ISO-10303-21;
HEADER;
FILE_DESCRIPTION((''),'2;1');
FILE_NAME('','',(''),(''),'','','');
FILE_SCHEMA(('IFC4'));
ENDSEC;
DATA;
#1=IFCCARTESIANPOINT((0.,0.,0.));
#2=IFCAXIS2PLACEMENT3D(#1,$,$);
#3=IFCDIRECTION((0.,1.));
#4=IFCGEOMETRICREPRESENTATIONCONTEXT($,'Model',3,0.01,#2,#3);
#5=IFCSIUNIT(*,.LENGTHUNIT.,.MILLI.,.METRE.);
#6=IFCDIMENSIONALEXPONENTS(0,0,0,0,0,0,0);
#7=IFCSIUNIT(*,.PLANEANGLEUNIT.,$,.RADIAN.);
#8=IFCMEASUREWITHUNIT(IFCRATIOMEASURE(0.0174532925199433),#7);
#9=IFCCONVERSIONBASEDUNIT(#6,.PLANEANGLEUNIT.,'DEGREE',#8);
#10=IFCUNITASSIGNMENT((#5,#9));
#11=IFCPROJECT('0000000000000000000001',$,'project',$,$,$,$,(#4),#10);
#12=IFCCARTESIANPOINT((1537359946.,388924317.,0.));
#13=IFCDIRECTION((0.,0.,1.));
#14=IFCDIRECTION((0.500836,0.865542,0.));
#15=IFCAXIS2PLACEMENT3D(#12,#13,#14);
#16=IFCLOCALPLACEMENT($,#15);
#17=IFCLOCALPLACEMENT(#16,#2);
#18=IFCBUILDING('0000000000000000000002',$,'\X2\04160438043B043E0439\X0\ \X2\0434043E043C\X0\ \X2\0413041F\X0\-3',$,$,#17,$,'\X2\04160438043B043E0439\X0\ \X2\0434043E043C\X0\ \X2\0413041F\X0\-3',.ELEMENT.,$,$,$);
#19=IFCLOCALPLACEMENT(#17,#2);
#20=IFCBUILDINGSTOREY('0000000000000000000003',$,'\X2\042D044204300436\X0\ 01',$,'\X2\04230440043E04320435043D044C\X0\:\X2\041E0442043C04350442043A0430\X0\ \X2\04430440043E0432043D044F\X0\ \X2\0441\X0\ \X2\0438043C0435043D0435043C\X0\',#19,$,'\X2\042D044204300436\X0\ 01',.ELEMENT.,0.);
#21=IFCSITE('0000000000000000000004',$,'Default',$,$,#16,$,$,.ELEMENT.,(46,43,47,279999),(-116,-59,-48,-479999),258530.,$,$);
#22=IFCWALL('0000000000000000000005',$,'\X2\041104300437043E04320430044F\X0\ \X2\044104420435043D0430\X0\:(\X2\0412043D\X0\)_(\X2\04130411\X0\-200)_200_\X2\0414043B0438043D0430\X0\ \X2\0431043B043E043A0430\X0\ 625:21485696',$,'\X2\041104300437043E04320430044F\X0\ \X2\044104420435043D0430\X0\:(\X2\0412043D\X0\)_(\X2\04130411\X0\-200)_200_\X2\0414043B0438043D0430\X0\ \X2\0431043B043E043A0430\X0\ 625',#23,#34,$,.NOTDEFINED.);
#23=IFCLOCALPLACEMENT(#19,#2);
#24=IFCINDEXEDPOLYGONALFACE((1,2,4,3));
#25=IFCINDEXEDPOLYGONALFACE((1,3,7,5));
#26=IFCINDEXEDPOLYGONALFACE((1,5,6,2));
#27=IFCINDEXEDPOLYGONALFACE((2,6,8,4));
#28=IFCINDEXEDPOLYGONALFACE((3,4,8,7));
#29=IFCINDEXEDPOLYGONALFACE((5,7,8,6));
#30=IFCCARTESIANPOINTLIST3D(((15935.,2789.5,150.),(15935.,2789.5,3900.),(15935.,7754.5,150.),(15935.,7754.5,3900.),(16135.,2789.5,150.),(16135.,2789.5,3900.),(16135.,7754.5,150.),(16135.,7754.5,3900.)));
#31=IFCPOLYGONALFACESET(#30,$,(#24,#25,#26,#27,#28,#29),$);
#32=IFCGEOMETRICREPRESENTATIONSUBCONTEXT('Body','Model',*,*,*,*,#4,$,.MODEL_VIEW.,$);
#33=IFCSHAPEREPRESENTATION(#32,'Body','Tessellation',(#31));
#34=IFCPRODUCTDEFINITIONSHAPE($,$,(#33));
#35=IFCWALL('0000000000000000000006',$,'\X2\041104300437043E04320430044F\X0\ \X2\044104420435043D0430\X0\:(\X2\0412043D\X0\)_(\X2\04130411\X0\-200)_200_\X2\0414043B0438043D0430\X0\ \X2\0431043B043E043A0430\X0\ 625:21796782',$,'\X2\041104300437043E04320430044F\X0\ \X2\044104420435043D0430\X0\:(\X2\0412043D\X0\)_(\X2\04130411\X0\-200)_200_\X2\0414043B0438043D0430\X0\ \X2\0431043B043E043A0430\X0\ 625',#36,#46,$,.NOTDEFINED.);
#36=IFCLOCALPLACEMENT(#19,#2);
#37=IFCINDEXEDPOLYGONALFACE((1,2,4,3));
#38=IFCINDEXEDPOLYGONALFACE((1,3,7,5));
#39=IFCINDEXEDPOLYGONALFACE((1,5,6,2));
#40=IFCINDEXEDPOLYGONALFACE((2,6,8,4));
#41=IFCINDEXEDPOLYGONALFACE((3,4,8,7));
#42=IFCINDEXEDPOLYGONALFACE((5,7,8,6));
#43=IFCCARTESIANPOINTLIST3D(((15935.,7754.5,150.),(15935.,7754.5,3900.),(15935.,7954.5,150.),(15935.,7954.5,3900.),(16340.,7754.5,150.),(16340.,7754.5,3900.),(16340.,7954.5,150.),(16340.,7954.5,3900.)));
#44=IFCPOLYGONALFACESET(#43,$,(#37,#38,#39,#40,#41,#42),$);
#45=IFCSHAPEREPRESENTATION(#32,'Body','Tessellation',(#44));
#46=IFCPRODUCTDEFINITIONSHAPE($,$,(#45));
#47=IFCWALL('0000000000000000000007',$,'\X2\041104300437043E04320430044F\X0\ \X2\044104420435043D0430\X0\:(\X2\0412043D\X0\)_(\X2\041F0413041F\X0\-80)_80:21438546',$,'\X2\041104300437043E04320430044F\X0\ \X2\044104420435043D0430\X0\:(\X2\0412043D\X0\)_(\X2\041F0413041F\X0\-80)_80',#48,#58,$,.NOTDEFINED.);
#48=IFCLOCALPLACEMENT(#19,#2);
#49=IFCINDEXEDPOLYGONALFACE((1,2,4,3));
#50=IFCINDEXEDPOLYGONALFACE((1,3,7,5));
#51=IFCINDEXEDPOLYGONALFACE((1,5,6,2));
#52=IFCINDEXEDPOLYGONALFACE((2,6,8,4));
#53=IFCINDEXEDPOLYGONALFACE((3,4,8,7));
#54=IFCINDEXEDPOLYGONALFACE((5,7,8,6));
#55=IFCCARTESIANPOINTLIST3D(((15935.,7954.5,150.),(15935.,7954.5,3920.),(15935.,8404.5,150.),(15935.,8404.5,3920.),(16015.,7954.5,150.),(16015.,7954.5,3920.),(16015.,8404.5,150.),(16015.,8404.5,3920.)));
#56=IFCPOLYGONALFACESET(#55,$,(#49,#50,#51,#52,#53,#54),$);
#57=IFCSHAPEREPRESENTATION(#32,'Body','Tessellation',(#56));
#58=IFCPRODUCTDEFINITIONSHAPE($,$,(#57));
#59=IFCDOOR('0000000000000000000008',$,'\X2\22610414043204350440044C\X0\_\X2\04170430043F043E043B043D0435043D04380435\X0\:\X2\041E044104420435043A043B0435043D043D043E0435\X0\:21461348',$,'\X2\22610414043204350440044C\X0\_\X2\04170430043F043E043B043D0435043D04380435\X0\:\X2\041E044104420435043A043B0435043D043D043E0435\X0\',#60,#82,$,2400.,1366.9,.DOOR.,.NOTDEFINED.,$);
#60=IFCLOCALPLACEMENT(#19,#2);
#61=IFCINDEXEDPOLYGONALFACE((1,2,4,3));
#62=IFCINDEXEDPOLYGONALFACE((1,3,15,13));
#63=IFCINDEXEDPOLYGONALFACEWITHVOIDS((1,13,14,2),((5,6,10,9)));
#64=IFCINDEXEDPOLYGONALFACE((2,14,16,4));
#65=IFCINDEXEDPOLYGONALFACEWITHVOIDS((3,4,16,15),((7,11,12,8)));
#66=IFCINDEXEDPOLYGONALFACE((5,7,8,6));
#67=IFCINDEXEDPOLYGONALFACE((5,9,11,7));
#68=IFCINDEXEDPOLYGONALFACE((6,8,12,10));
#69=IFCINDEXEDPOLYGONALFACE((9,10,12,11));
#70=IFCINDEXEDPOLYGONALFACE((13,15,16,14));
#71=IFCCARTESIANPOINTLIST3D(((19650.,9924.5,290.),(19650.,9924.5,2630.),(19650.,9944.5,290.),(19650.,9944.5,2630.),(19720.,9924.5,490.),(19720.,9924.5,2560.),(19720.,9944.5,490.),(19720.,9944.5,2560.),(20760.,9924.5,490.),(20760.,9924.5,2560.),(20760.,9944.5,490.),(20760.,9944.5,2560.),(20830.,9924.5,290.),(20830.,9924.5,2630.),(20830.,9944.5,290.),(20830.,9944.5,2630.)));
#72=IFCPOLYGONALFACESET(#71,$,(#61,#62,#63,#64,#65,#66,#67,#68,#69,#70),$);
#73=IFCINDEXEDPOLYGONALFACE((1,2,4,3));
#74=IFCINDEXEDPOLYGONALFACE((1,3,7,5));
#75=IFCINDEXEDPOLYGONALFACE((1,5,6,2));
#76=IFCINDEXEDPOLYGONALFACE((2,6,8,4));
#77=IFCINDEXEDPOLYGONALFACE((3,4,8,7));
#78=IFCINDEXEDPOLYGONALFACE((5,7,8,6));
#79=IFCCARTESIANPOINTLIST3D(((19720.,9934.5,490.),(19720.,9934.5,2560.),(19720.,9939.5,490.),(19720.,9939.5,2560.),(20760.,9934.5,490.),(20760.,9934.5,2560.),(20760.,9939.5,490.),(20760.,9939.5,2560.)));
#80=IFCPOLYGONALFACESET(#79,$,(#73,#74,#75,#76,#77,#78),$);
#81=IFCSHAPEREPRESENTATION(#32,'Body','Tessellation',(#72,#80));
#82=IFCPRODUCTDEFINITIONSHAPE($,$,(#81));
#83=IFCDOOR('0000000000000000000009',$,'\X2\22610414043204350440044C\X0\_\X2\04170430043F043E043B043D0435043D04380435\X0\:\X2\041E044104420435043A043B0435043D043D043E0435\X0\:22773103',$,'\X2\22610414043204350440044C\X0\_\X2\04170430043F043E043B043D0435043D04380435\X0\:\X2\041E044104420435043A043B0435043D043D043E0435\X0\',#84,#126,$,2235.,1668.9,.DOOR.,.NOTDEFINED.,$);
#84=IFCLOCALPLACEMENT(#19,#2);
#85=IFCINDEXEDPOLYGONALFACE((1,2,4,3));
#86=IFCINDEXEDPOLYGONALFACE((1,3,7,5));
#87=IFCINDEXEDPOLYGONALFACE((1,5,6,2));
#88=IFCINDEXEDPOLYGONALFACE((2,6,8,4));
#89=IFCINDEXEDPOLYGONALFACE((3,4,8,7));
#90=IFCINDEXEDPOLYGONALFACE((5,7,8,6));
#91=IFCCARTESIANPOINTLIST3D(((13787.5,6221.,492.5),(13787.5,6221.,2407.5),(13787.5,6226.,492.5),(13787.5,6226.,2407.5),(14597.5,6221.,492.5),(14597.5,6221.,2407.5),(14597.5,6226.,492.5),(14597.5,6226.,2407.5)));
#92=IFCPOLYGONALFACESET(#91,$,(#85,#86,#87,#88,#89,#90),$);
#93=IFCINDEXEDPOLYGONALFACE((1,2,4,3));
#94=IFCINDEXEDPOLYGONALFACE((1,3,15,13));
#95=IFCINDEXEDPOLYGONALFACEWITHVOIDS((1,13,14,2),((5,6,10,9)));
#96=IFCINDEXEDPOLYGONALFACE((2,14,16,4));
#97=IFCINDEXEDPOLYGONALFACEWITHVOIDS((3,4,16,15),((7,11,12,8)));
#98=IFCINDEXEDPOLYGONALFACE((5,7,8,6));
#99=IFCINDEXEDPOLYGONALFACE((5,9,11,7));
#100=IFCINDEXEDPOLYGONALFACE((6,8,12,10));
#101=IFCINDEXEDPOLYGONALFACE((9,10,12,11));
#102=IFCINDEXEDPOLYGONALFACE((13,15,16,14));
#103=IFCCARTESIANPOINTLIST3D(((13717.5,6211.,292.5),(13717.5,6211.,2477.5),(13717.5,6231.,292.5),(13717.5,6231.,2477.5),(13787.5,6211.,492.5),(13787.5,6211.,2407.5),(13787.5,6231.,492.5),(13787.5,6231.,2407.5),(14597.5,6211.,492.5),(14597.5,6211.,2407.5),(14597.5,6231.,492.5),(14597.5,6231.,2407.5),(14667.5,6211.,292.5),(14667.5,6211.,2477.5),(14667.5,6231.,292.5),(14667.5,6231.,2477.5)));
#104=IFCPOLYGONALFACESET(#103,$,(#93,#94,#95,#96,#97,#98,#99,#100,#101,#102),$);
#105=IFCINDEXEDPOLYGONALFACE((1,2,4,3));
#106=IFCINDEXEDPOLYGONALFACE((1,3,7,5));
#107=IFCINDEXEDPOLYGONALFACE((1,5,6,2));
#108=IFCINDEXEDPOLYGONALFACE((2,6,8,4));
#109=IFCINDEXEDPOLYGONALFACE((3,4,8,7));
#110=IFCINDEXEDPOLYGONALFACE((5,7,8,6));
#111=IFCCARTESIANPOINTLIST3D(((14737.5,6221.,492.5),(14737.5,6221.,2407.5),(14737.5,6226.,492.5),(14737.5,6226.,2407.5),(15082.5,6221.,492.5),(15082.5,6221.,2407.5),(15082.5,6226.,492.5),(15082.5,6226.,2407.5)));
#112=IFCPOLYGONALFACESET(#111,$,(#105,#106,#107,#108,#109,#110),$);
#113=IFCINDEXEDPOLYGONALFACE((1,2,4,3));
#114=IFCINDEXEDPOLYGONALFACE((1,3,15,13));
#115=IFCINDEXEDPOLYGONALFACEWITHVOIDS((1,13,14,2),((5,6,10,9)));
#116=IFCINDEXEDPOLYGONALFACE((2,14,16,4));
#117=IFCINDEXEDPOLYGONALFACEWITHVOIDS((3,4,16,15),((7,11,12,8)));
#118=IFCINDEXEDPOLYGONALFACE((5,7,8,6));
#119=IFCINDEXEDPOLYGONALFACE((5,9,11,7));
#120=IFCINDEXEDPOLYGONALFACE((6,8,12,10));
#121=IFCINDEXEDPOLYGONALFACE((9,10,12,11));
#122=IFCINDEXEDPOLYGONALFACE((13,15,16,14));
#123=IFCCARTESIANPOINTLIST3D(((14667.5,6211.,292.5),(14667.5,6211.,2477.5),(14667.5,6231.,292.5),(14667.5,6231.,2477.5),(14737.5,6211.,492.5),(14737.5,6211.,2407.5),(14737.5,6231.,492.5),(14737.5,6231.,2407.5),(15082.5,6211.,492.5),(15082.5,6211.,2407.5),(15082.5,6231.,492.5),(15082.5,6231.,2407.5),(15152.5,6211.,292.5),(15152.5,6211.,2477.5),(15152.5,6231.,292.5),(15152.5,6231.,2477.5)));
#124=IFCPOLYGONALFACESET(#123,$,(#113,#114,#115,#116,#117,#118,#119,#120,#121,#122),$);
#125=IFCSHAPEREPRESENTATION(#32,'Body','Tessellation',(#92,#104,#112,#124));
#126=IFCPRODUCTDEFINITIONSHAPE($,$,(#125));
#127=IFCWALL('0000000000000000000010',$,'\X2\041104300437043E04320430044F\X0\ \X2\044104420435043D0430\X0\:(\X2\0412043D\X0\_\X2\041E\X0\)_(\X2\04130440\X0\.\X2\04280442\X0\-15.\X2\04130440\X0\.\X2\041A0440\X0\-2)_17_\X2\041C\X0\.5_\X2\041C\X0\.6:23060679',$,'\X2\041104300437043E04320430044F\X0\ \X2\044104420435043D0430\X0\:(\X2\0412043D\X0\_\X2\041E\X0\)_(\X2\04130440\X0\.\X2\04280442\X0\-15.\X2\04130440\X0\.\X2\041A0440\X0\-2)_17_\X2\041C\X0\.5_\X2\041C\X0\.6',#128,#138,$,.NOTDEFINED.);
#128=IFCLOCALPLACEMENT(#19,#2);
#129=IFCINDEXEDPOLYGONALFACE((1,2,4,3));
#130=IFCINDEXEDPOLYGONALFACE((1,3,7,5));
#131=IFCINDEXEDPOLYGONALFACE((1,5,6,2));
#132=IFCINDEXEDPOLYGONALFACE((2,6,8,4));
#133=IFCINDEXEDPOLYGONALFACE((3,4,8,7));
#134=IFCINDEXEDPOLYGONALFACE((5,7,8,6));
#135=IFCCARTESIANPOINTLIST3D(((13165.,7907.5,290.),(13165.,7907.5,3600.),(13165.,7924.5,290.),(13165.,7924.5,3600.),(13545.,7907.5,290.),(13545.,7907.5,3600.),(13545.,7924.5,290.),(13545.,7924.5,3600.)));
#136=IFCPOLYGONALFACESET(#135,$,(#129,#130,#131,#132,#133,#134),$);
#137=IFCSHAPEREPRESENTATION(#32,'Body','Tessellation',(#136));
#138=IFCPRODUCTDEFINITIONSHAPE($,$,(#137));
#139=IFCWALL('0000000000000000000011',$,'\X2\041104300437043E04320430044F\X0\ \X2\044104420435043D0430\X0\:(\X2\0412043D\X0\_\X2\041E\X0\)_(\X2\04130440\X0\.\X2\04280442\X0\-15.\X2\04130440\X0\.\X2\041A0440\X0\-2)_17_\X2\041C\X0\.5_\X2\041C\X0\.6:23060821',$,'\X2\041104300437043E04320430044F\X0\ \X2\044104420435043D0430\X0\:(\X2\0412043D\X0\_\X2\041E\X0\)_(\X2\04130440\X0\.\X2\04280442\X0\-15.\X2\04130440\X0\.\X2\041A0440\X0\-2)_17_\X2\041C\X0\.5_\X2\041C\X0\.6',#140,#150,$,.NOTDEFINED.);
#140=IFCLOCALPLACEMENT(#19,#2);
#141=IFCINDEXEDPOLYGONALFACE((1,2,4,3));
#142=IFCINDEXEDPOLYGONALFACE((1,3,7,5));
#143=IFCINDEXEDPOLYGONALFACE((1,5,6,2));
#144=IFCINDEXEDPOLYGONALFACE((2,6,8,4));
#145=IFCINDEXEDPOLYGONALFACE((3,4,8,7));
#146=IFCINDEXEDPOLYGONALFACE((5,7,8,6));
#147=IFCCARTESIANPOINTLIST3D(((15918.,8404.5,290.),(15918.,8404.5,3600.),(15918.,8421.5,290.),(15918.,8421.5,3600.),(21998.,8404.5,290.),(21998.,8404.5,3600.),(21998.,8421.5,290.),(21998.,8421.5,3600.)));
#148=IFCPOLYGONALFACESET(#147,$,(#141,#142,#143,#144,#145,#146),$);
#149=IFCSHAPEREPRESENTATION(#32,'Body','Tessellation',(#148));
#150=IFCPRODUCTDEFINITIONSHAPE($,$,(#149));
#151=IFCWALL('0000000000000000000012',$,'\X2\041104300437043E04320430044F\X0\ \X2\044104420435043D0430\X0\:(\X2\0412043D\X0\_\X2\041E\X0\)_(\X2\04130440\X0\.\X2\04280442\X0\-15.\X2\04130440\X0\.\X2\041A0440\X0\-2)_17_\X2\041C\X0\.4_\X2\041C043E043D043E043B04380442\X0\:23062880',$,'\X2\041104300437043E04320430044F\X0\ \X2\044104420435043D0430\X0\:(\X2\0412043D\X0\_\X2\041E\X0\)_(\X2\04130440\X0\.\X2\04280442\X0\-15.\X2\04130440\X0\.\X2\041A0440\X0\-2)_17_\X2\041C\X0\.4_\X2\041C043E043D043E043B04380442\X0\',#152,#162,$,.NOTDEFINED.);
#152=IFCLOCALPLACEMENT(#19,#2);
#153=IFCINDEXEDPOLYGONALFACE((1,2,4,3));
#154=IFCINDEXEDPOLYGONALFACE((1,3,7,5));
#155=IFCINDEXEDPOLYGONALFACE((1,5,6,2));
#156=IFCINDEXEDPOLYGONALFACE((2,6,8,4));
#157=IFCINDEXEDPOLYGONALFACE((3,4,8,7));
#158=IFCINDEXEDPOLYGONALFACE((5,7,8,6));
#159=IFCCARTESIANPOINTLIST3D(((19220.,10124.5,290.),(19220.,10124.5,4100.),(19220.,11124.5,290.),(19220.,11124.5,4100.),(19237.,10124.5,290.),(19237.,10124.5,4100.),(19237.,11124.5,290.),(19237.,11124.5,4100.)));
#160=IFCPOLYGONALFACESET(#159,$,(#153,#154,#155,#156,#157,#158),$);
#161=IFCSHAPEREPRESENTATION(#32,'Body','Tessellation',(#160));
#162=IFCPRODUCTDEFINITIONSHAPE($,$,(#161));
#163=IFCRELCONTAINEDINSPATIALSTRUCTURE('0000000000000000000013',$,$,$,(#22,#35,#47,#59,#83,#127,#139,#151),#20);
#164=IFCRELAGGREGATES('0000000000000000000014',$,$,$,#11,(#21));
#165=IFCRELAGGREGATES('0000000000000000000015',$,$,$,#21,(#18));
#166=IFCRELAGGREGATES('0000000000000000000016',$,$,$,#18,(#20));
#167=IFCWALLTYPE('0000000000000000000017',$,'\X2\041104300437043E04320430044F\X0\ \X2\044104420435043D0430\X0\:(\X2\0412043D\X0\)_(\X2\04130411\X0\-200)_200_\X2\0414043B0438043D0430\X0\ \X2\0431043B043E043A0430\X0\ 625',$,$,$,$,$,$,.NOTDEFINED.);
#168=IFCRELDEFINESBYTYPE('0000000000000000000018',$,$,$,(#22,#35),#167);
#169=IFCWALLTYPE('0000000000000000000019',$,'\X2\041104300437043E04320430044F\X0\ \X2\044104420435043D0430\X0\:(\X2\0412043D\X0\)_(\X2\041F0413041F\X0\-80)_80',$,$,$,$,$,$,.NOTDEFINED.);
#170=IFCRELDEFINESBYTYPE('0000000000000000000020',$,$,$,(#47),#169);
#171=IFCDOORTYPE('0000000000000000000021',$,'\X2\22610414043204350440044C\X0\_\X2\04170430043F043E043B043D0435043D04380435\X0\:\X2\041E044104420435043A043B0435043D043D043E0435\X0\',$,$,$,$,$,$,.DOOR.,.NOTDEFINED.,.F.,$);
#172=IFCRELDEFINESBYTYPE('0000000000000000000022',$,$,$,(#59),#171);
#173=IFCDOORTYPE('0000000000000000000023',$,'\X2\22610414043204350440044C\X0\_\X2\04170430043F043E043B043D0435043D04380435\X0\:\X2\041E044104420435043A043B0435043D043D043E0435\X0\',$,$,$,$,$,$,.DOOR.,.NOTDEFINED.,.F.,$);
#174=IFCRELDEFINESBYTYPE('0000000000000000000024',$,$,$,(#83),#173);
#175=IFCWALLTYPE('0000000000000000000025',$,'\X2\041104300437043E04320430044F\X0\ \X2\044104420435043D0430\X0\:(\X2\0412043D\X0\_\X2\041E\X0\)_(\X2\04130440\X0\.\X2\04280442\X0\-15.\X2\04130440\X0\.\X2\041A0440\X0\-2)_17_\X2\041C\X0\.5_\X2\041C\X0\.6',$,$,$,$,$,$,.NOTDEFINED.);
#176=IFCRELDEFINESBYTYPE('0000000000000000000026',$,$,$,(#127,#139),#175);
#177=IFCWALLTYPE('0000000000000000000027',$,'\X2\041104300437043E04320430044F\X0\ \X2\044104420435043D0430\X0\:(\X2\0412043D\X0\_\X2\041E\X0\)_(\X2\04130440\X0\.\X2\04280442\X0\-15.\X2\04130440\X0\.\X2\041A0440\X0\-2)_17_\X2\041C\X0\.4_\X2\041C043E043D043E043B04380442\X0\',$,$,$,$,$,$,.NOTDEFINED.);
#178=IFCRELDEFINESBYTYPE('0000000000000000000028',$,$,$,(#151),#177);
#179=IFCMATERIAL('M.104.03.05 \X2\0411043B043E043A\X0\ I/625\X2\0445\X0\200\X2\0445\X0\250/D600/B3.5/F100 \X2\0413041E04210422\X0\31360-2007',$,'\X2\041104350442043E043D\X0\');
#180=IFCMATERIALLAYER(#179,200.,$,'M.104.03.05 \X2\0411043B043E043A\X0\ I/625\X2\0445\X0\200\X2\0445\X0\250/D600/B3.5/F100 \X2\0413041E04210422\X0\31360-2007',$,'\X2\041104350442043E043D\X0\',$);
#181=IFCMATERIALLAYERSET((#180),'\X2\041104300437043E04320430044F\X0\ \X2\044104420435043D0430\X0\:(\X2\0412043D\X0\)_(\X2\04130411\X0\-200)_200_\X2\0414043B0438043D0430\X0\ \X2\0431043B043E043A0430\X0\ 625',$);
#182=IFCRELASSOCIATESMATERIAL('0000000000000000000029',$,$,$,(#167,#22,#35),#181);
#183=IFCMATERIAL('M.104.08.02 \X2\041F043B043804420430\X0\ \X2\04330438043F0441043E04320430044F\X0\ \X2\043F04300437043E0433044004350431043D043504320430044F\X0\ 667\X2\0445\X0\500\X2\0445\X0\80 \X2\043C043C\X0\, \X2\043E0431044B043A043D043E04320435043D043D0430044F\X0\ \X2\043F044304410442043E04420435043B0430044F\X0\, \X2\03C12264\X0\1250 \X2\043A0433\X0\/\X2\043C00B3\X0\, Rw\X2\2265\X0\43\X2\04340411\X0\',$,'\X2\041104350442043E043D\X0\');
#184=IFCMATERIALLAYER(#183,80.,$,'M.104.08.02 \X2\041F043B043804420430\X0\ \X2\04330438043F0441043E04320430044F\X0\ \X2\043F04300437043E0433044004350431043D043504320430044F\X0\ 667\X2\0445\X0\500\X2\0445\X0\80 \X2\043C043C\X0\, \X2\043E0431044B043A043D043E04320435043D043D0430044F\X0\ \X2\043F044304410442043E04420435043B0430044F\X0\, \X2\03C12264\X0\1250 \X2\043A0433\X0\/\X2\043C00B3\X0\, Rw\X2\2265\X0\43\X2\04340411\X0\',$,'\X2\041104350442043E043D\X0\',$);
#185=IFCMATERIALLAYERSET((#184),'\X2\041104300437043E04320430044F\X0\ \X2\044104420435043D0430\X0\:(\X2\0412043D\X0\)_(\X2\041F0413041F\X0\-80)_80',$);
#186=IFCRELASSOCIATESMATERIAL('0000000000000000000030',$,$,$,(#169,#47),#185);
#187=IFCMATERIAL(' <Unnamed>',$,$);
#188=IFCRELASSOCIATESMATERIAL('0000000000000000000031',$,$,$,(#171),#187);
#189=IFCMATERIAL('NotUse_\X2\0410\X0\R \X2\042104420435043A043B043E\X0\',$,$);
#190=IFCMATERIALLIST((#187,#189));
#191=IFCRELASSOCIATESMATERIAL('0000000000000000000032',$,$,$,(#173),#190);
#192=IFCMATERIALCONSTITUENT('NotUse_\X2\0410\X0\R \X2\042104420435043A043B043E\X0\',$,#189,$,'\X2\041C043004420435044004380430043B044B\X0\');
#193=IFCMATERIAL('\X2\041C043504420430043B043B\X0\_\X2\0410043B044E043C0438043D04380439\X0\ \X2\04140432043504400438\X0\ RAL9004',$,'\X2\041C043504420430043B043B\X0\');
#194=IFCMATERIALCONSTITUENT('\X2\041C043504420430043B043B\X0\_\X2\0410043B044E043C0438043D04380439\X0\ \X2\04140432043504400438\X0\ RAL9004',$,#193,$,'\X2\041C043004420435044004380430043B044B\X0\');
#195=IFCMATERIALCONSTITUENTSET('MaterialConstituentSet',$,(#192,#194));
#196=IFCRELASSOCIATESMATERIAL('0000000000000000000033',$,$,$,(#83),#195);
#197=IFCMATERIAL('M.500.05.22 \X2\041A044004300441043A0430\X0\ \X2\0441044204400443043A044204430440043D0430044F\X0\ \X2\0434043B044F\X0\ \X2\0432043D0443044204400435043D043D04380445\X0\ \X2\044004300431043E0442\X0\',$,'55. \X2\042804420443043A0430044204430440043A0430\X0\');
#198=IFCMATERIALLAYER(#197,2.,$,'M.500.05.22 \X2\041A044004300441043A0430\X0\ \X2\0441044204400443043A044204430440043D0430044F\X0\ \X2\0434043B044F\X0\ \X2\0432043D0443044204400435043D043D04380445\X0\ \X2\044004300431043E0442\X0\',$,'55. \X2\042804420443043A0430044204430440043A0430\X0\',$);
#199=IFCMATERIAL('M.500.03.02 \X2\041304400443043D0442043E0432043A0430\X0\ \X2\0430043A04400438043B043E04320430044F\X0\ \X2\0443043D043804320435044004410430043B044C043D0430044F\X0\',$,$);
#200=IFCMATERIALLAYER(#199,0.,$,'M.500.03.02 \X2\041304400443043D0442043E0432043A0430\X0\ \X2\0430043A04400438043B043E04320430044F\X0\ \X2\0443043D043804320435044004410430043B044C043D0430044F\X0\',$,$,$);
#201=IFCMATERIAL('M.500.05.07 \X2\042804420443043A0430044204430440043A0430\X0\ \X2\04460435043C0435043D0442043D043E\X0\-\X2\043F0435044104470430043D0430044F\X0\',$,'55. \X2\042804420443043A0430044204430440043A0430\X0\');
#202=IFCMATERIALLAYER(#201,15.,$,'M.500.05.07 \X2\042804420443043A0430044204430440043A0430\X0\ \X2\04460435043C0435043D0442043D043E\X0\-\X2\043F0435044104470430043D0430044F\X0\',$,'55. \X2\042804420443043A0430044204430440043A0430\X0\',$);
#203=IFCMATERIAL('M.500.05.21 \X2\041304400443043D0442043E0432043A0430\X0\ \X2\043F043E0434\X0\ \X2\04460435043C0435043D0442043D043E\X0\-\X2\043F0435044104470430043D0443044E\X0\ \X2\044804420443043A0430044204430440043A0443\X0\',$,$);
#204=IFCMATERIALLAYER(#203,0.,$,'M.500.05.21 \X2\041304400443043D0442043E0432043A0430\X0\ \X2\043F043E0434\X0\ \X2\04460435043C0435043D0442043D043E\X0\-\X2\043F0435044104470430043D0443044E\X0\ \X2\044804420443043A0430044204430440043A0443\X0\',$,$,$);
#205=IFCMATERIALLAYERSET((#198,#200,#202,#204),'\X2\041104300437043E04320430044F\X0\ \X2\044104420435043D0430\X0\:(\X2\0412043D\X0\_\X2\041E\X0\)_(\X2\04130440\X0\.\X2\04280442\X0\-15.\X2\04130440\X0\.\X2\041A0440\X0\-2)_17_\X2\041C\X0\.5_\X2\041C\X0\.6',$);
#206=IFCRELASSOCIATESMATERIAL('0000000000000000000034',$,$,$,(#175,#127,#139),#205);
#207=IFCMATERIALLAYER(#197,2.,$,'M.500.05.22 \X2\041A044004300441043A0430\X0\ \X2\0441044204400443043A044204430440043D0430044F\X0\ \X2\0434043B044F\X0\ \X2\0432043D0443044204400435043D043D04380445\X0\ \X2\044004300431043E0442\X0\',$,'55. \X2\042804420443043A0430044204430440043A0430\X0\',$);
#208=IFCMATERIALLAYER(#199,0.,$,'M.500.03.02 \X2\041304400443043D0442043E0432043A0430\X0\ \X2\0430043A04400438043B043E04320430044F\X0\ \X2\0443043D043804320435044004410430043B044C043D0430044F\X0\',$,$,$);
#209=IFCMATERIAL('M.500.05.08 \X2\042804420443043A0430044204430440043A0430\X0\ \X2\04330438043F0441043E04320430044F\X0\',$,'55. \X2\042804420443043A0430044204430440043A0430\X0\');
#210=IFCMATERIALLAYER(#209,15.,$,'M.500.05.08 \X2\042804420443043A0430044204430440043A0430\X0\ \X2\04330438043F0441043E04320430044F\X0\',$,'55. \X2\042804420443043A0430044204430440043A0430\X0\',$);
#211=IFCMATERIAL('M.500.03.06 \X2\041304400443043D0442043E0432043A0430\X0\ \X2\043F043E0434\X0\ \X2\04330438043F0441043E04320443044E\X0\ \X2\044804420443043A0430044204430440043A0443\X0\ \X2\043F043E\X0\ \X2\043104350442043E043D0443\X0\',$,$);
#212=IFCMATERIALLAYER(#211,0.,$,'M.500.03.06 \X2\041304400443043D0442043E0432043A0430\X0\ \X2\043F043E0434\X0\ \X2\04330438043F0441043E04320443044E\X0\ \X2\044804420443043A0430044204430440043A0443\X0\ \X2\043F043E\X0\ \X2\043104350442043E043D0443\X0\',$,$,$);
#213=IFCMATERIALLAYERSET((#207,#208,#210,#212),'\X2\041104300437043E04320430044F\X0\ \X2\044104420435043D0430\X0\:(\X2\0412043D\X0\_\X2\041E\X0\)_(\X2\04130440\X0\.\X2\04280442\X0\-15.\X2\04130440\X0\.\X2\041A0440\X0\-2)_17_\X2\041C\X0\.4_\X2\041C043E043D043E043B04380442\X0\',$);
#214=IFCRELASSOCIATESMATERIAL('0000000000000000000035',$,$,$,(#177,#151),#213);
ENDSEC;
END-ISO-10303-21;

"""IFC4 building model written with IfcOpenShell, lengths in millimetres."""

from ifc_helpers import new_model, entity, si_unit, converted_unit, direction, frame, frame_2d, origin, place, context, subcontext, project, spatial, polyline, rectangle, outline, extrude, source, transform, mapped, material, material_list, layer, layer_set, layer_usage, constituent, constituent_set, type_object, type_shapes, element, save


model = new_model("IFC4")

# Units and contexts
model_context = context("Model", 3, precision=0.01, world=origin(), true_north=direction((0.0, 1.0)))
body_context = subcontext(model_context, "Body", "Model", "MODEL_VIEW")
ifc_project = project(units=[si_unit("LENGTHUNIT", "METRE", prefix="MILLI"), converted_unit("PLANEANGLEUNIT", "DEGREE", entity("IfcRatioMeasure", 0.0174532925199433), si_unit("PLANEANGLEUNIT", "RADIAN"), dimensions=[0, 0, 0, 0, 0, 0, 0])], contexts=[model_context])

# Site, building, storey
site_placement = place(None, frame((1537359946.0, 388924317.0, 0.0), z_axis=(0.0, 0.0, 1.0), x_axis=(0.500836, 0.865542, 0.0)))
site = spatial("IfcSite", under=ifc_project, at=site_placement, Name="Default", CompositionType="ELEMENT", RefLatitude=(46, 43, 47, 279999), RefLongitude=(-116, -59, -48, -479999), RefElevation=258530.0)
building_placement = place(site_placement, origin())
building = spatial("IfcBuilding", under=site, at=building_placement, Name="Жилой дом ГП-3", LongName="Жилой дом ГП-3", CompositionType="ELEMENT")
storey_placement = place(building_placement, origin())
storey = spatial("IfcBuildingStorey", under=building, at=storey_placement, Name="Этаж 01", ObjectType="Уровень:Отметка уровня с именем", LongName="Этаж 01", CompositionType="ELEMENT", Elevation=0.0)

# Walls
ifc_material_1 = material(Name="M.104.03.05 Блок I/625х200х250/D600/B3.5/F100 ГОСТ31360-2007", Category="Бетон")
ifc_layer_1 = layer(ifc_material_1, 200.0, Name="M.104.03.05 Блок I/625х200х250/D600/B3.5/F100 ГОСТ31360-2007", Category="Бетон")
ifc_layer_set_1 = layer_set([ifc_layer_1], Name="Базовая стена:(Вн)_(ГБ-200)_200_Длина блока 625")
ifc_layer_usage_1 = layer_usage(ifc_layer_set_1, "AXIS2", "NEGATIVE", 100.0)
wall_type_1 = type_object("IfcWallType", Name="Базовая стена:(Вн)_(ГБ-200)_200_Длина блока 625", PredefinedType="NOTDEFINED", material=ifc_layer_set_1)
wall_1_placement = place(storey_placement, frame((16035.0, 7754.5, 150.0), z_axis=(0.0, 0.0, 1.0), x_axis=(0.0, -1.0, 0.0)))
element("IfcWall", 1, at=wall_1_placement, inside=storey, type_object=wall_type_1, material=ifc_layer_usage_1, Name="Базовая стена:(Вн)_(ГБ-200)_200_Длина блока 625:21485696", ObjectType="Базовая стена:(Вн)_(ГБ-200)_200_Длина блока 625", PredefinedType="NOTDEFINED", context=body_context, shape_type="SweptSolid", body=[
    extrude(rectangle(XDim=4965.0, YDim=200.0, at=frame_2d((2482.5, 0.0), x_axis=(-1.0, 0.0))), origin(), (0.0, 0.0, 1.0), 3750.0),
])
ifc_layer_usage_2 = layer_usage(ifc_layer_set_1, "AXIS2", "NEGATIVE", 100.0)
wall_2_placement = place(storey_placement, frame((16340.0, 7854.5, 150.0), z_axis=(0.0, 0.0, 1.0), x_axis=(-1.0, 0.0, 0.0)))
element("IfcWall", 2, at=wall_2_placement, inside=storey, type_object=wall_type_1, material=ifc_layer_usage_2, Name="Базовая стена:(Вн)_(ГБ-200)_200_Длина блока 625:21796782", ObjectType="Базовая стена:(Вн)_(ГБ-200)_200_Длина блока 625", PredefinedType="NOTDEFINED", context=body_context, shape_type="SweptSolid", body=[
    extrude(rectangle(XDim=405.0, YDim=200.0, at=frame_2d((202.5, 0.0), x_axis=(-1.0, 0.0))), origin(), (0.0, 0.0, 1.0), 3750.0),
])
ifc_material_2 = material(Name="M.104.08.02 Плита гипсовая пазогребневая 667х500х80 мм, обыкновенная пустотелая, ρ≤1250 кг/м³, Rw≥43дБ", Category="Бетон")
ifc_layer_2 = layer(ifc_material_2, 80.0, Name="M.104.08.02 Плита гипсовая пазогребневая 667х500х80 мм, обыкновенная пустотелая, ρ≤1250 кг/м³, Rw≥43дБ", Category="Бетон")
ifc_layer_set_2 = layer_set([ifc_layer_2], Name="Базовая стена:(Вн)_(ПГП-80)_80")
ifc_layer_usage_3 = layer_usage(ifc_layer_set_2, "AXIS2", "NEGATIVE", 40.0)
wall_type_2 = type_object("IfcWallType", Name="Базовая стена:(Вн)_(ПГП-80)_80", PredefinedType="NOTDEFINED", material=ifc_layer_set_2)
wall_3_placement = place(storey_placement, frame((15975.0, 7954.5, 150.0), z_axis=(0.0, 0.0, 1.0), x_axis=(0.0, 1.0, 0.0)))
element("IfcWall", 3, at=wall_3_placement, inside=storey, type_object=wall_type_2, material=ifc_layer_usage_3, Name="Базовая стена:(Вн)_(ПГП-80)_80:21438546", ObjectType="Базовая стена:(Вн)_(ПГП-80)_80", PredefinedType="NOTDEFINED", context=body_context, shape_type="SweptSolid", body=[
    extrude(rectangle(XDim=450.0, YDim=80.0, at=frame_2d((225.0, 0.0), x_axis=(-1.0, 0.0))), origin(), (0.0, 0.0, 1.0), 3770.0),
])

# Doors
ifc_material_3 = material(Name=" <Unnamed>")
door_type_1 = type_object("IfcDoorType", Name="≡Дверь_Заполнение:Остекленное", OperationType="NOTDEFINED", ParameterTakesPrecedence=False, PredefinedType="DOOR", material=ifc_material_3)
shared_shape_1 = source(origin(), body_context, "Body", "SweptSolid", [
    extrude(outline(polyline([(-1170.0, -590.0), (1170.0, -590.0), (1170.0, 590.0), (-1170.0, 590.0), (-1170.0, -590.0)]), holes=[polyline([(-1100.0, -520.0), (-1100.0, 520.0), (970.0, 520.0), (970.0, -520.0), (-1100.0, -520.0)])]), frame((0.0, -20.0, 1170.0), z_axis=(0.0, 1.0, 0.0), x_axis=(0.0, 0.0, -1.0)), (0.0, 0.0, 1.0), 20.0),
    extrude(rectangle(XDim=5.0, YDim=1040.0, at=frame_2d((0.0, 0.0), x_axis=(1.0, 0.0))), frame((0.0, -12.5, 200.0), z_axis=(0.0, 0.0, 1.0), x_axis=(0.0, 1.0, 0.0)), (0.0, 0.0, 1.0), 2070.0),
])
type_shapes(door_type_1, [shared_shape_1])
door_1_placement = place(storey_placement, frame((20240.0, 9924.5, 290.0), z_axis=(0.0, 0.0, 1.0), x_axis=(-1.0, 0.0, 0.0)))
element("IfcDoor", 4, at=door_1_placement, inside=storey, type_object=door_type_1, Name="≡Дверь_Заполнение:Остекленное:21461348", ObjectType="≡Дверь_Заполнение:Остекленное", OperationType="NOTDEFINED", OverallHeight=2400.0, OverallWidth=1366.9, PredefinedType="DOOR", context=body_context, shape_type="MappedRepresentation", body=[
    mapped(shared_shape_1, transform((0.0, 0.0, 0.0), scale=1.0)),
])
ifc_material_4 = material(Name="NotUse_АR Стекло")
ifc_constituent_1 = constituent(ifc_material_4, Name="NotUse_АR Стекло", Category="Материалы")
ifc_material_5 = material(Name="Металл_Алюминий Двери RAL9004", Category="Металл")
ifc_constituent_2 = constituent(ifc_material_5, Name="Металл_Алюминий Двери RAL9004", Category="Материалы")
ifc_constituent_set = constituent_set(constituents=[ifc_constituent_1, ifc_constituent_2], Name="MaterialConstituentSet")
ifc_material_list = material_list([ifc_material_3, ifc_material_4])
door_type_2 = type_object("IfcDoorType", Name="≡Дверь_Заполнение:Остекленное", OperationType="NOTDEFINED", ParameterTakesPrecedence=False, PredefinedType="DOOR", material=ifc_material_list)
shared_shape_2 = source(origin(), body_context, "Body", "SweptSolid", [
    extrude(rectangle(XDim=810.0, YDim=5.0, at=frame_2d((0.0, 0.0), x_axis=(1.0, 0.0))), frame((-242.5, 12.5, 200.0), z_axis=(0.0, 0.0, 1.0), x_axis=(-1.0, 0.0, 0.0)), (0.0, 0.0, 1.0), 1915.0),
    extrude(outline(polyline([(-1092.5, -475.0), (1092.5, -475.0), (1092.5, 475.0), (-1092.5, 475.0), (-1092.5, -475.0)]), holes=[polyline([(-1022.5, -405.0), (-1022.5, 405.0), (892.5, 405.0), (892.5, -405.0), (-1022.5, -405.0)])]), frame((-242.5, 0.0, 1092.5), z_axis=(0.0, 1.0, 0.0), x_axis=(0.0, 0.0, -1.0)), (0.0, 0.0, 1.0), 20.0),
    extrude(rectangle(XDim=345.0, YDim=5.0, at=frame_2d((0.0, 0.0), x_axis=(1.0, 0.0))), frame((475.0, 12.5, 200.0), z_axis=(0.0, 0.0, 1.0), x_axis=(-1.0, 0.0, 0.0)), (0.0, 0.0, 1.0), 1915.0),
    extrude(outline(polyline([(-1092.5, -242.5), (1092.5, -242.5), (1092.5, 242.5), (-1092.5, 242.5), (-1092.5, -242.5)]), holes=[polyline([(-1022.5, -172.5), (-1022.5, 172.5), (892.5, 172.5), (892.5, -172.5), (-1022.5, -172.5)])]), frame((475.0, 0.0, 1092.5), z_axis=(0.0, 1.0, 0.0), x_axis=(0.0, 0.0, -1.0)), (0.0, 0.0, 1.0), 20.0),
])
type_shapes(door_type_2, [shared_shape_2])
door_2_placement = place(storey_placement, frame((14435.0, 6211.0, 292.5)))
element("IfcDoor", 5, at=door_2_placement, inside=storey, type_object=door_type_2, material=ifc_constituent_set, Name="≡Дверь_Заполнение:Остекленное:22773103", ObjectType="≡Дверь_Заполнение:Остекленное", OperationType="NOTDEFINED", OverallHeight=2235.0, OverallWidth=1668.9, PredefinedType="DOOR", context=body_context, shape_type="MappedRepresentation", body=[
    mapped(shared_shape_2, transform((0.0, 0.0, 0.0), scale=1.0)),
])

# Walls
ifc_material_6 = material(Name="M.500.05.22 Краска структурная для внутренних работ", Category="55. Штукатурка")
ifc_layer_3 = layer(ifc_material_6, 2.0, Name="M.500.05.22 Краска структурная для внутренних работ", Category="55. Штукатурка")
ifc_material_7 = material(Name="M.500.03.02 Грунтовка акриловая универсальная")
ifc_layer_4 = layer(ifc_material_7, 0.0, Name="M.500.03.02 Грунтовка акриловая универсальная")
ifc_material_8 = material(Name="M.500.05.07 Штукатурка цементно-песчаная", Category="55. Штукатурка")
ifc_layer_5 = layer(ifc_material_8, 15.0, Name="M.500.05.07 Штукатурка цементно-песчаная", Category="55. Штукатурка")
ifc_material_9 = material(Name="M.500.05.21 Грунтовка под цементно-песчаную штукатурку")
ifc_layer_6 = layer(ifc_material_9, 0.0, Name="M.500.05.21 Грунтовка под цементно-песчаную штукатурку")
ifc_layer_set_3 = layer_set([ifc_layer_3, ifc_layer_4, ifc_layer_5, ifc_layer_6], Name="Базовая стена:(Вн_О)_(Гр.Шт-15.Гр.Кр-2)_17_М.5_М.6")
ifc_layer_usage_4 = layer_usage(ifc_layer_set_3, "AXIS2", "NEGATIVE", 8.5)
wall_type_3 = type_object("IfcWallType", Name="Базовая стена:(Вн_О)_(Гр.Шт-15.Гр.Кр-2)_17_М.5_М.6", PredefinedType="NOTDEFINED", material=ifc_layer_set_3)
wall_4_placement = place(storey_placement, frame((13545.0, 7916.0, 290.0), z_axis=(0.0, 0.0, 1.0), x_axis=(-1.0, 0.0, 0.0)))
element("IfcWall", 6, at=wall_4_placement, inside=storey, type_object=wall_type_3, material=ifc_layer_usage_4, Name="Базовая стена:(Вн_О)_(Гр.Шт-15.Гр.Кр-2)_17_М.5_М.6:23060679", ObjectType="Базовая стена:(Вн_О)_(Гр.Шт-15.Гр.Кр-2)_17_М.5_М.6", PredefinedType="NOTDEFINED", context=body_context, shape_type="SweptSolid", body=[
    extrude(rectangle(XDim=380.0, YDim=17.0, at=frame_2d((190.0, 0.0), x_axis=(-1.0, 0.0))), origin(), (0.0, 0.0, 1.0), 3310.0),
])
ifc_layer_usage_5 = layer_usage(ifc_layer_set_3, "AXIS2", "NEGATIVE", 8.5)
wall_5_placement = place(storey_placement, frame((15918.0, 8413.0, 290.0)))
element("IfcWall", 7, at=wall_5_placement, inside=storey, type_object=wall_type_3, material=ifc_layer_usage_5, Name="Базовая стена:(Вн_О)_(Гр.Шт-15.Гр.Кр-2)_17_М.5_М.6:23060821", ObjectType="Базовая стена:(Вн_О)_(Гр.Шт-15.Гр.Кр-2)_17_М.5_М.6", PredefinedType="NOTDEFINED", context=body_context, shape_type="SweptSolid", body=[
    extrude(rectangle(XDim=6080.0, YDim=17.0, at=frame_2d((3040.0, 0.0), x_axis=(-1.0, 0.0))), origin(), (0.0, 0.0, 1.0), 3310.0),
])
ifc_layer_7 = layer(ifc_material_6, 2.0, Name="M.500.05.22 Краска структурная для внутренних работ", Category="55. Штукатурка")
ifc_layer_8 = layer(ifc_material_7, 0.0, Name="M.500.03.02 Грунтовка акриловая универсальная")
ifc_material_10 = material(Name="M.500.05.08 Штукатурка гипсовая", Category="55. Штукатурка")
ifc_layer_9 = layer(ifc_material_10, 15.0, Name="M.500.05.08 Штукатурка гипсовая", Category="55. Штукатурка")
ifc_material_11 = material(Name="M.500.03.06 Грунтовка под гипсовую штукатурку по бетону")
ifc_layer_10 = layer(ifc_material_11, 0.0, Name="M.500.03.06 Грунтовка под гипсовую штукатурку по бетону")
ifc_layer_set_4 = layer_set([ifc_layer_7, ifc_layer_8, ifc_layer_9, ifc_layer_10], Name="Базовая стена:(Вн_О)_(Гр.Шт-15.Гр.Кр-2)_17_М.4_Монолит")
ifc_layer_usage_6 = layer_usage(ifc_layer_set_4, "AXIS2", "NEGATIVE", 8.5)
wall_type_4 = type_object("IfcWallType", Name="Базовая стена:(Вн_О)_(Гр.Шт-15.Гр.Кр-2)_17_М.4_Монолит", PredefinedType="NOTDEFINED", material=ifc_layer_set_4)
wall_6_placement = place(storey_placement, frame((19228.5, 11124.5, 290.0), z_axis=(0.0, 0.0, 1.0), x_axis=(0.0, -1.0, 0.0)))
element("IfcWall", 8, at=wall_6_placement, inside=storey, type_object=wall_type_4, material=ifc_layer_usage_6, Name="Базовая стена:(Вн_О)_(Гр.Шт-15.Гр.Кр-2)_17_М.4_Монолит:23062880", ObjectType="Базовая стена:(Вн_О)_(Гр.Шт-15.Гр.Кр-2)_17_М.4_Монолит", PredefinedType="NOTDEFINED", context=body_context, shape_type="SweptSolid", body=[
    extrude(rectangle(XDim=1000.0, YDim=17.0, at=frame_2d((500.0, 0.0), x_axis=(-1.0, 0.0))), origin(), (0.0, 0.0, 1.0), 3810.0),
])

save(model, "model.ifc")
